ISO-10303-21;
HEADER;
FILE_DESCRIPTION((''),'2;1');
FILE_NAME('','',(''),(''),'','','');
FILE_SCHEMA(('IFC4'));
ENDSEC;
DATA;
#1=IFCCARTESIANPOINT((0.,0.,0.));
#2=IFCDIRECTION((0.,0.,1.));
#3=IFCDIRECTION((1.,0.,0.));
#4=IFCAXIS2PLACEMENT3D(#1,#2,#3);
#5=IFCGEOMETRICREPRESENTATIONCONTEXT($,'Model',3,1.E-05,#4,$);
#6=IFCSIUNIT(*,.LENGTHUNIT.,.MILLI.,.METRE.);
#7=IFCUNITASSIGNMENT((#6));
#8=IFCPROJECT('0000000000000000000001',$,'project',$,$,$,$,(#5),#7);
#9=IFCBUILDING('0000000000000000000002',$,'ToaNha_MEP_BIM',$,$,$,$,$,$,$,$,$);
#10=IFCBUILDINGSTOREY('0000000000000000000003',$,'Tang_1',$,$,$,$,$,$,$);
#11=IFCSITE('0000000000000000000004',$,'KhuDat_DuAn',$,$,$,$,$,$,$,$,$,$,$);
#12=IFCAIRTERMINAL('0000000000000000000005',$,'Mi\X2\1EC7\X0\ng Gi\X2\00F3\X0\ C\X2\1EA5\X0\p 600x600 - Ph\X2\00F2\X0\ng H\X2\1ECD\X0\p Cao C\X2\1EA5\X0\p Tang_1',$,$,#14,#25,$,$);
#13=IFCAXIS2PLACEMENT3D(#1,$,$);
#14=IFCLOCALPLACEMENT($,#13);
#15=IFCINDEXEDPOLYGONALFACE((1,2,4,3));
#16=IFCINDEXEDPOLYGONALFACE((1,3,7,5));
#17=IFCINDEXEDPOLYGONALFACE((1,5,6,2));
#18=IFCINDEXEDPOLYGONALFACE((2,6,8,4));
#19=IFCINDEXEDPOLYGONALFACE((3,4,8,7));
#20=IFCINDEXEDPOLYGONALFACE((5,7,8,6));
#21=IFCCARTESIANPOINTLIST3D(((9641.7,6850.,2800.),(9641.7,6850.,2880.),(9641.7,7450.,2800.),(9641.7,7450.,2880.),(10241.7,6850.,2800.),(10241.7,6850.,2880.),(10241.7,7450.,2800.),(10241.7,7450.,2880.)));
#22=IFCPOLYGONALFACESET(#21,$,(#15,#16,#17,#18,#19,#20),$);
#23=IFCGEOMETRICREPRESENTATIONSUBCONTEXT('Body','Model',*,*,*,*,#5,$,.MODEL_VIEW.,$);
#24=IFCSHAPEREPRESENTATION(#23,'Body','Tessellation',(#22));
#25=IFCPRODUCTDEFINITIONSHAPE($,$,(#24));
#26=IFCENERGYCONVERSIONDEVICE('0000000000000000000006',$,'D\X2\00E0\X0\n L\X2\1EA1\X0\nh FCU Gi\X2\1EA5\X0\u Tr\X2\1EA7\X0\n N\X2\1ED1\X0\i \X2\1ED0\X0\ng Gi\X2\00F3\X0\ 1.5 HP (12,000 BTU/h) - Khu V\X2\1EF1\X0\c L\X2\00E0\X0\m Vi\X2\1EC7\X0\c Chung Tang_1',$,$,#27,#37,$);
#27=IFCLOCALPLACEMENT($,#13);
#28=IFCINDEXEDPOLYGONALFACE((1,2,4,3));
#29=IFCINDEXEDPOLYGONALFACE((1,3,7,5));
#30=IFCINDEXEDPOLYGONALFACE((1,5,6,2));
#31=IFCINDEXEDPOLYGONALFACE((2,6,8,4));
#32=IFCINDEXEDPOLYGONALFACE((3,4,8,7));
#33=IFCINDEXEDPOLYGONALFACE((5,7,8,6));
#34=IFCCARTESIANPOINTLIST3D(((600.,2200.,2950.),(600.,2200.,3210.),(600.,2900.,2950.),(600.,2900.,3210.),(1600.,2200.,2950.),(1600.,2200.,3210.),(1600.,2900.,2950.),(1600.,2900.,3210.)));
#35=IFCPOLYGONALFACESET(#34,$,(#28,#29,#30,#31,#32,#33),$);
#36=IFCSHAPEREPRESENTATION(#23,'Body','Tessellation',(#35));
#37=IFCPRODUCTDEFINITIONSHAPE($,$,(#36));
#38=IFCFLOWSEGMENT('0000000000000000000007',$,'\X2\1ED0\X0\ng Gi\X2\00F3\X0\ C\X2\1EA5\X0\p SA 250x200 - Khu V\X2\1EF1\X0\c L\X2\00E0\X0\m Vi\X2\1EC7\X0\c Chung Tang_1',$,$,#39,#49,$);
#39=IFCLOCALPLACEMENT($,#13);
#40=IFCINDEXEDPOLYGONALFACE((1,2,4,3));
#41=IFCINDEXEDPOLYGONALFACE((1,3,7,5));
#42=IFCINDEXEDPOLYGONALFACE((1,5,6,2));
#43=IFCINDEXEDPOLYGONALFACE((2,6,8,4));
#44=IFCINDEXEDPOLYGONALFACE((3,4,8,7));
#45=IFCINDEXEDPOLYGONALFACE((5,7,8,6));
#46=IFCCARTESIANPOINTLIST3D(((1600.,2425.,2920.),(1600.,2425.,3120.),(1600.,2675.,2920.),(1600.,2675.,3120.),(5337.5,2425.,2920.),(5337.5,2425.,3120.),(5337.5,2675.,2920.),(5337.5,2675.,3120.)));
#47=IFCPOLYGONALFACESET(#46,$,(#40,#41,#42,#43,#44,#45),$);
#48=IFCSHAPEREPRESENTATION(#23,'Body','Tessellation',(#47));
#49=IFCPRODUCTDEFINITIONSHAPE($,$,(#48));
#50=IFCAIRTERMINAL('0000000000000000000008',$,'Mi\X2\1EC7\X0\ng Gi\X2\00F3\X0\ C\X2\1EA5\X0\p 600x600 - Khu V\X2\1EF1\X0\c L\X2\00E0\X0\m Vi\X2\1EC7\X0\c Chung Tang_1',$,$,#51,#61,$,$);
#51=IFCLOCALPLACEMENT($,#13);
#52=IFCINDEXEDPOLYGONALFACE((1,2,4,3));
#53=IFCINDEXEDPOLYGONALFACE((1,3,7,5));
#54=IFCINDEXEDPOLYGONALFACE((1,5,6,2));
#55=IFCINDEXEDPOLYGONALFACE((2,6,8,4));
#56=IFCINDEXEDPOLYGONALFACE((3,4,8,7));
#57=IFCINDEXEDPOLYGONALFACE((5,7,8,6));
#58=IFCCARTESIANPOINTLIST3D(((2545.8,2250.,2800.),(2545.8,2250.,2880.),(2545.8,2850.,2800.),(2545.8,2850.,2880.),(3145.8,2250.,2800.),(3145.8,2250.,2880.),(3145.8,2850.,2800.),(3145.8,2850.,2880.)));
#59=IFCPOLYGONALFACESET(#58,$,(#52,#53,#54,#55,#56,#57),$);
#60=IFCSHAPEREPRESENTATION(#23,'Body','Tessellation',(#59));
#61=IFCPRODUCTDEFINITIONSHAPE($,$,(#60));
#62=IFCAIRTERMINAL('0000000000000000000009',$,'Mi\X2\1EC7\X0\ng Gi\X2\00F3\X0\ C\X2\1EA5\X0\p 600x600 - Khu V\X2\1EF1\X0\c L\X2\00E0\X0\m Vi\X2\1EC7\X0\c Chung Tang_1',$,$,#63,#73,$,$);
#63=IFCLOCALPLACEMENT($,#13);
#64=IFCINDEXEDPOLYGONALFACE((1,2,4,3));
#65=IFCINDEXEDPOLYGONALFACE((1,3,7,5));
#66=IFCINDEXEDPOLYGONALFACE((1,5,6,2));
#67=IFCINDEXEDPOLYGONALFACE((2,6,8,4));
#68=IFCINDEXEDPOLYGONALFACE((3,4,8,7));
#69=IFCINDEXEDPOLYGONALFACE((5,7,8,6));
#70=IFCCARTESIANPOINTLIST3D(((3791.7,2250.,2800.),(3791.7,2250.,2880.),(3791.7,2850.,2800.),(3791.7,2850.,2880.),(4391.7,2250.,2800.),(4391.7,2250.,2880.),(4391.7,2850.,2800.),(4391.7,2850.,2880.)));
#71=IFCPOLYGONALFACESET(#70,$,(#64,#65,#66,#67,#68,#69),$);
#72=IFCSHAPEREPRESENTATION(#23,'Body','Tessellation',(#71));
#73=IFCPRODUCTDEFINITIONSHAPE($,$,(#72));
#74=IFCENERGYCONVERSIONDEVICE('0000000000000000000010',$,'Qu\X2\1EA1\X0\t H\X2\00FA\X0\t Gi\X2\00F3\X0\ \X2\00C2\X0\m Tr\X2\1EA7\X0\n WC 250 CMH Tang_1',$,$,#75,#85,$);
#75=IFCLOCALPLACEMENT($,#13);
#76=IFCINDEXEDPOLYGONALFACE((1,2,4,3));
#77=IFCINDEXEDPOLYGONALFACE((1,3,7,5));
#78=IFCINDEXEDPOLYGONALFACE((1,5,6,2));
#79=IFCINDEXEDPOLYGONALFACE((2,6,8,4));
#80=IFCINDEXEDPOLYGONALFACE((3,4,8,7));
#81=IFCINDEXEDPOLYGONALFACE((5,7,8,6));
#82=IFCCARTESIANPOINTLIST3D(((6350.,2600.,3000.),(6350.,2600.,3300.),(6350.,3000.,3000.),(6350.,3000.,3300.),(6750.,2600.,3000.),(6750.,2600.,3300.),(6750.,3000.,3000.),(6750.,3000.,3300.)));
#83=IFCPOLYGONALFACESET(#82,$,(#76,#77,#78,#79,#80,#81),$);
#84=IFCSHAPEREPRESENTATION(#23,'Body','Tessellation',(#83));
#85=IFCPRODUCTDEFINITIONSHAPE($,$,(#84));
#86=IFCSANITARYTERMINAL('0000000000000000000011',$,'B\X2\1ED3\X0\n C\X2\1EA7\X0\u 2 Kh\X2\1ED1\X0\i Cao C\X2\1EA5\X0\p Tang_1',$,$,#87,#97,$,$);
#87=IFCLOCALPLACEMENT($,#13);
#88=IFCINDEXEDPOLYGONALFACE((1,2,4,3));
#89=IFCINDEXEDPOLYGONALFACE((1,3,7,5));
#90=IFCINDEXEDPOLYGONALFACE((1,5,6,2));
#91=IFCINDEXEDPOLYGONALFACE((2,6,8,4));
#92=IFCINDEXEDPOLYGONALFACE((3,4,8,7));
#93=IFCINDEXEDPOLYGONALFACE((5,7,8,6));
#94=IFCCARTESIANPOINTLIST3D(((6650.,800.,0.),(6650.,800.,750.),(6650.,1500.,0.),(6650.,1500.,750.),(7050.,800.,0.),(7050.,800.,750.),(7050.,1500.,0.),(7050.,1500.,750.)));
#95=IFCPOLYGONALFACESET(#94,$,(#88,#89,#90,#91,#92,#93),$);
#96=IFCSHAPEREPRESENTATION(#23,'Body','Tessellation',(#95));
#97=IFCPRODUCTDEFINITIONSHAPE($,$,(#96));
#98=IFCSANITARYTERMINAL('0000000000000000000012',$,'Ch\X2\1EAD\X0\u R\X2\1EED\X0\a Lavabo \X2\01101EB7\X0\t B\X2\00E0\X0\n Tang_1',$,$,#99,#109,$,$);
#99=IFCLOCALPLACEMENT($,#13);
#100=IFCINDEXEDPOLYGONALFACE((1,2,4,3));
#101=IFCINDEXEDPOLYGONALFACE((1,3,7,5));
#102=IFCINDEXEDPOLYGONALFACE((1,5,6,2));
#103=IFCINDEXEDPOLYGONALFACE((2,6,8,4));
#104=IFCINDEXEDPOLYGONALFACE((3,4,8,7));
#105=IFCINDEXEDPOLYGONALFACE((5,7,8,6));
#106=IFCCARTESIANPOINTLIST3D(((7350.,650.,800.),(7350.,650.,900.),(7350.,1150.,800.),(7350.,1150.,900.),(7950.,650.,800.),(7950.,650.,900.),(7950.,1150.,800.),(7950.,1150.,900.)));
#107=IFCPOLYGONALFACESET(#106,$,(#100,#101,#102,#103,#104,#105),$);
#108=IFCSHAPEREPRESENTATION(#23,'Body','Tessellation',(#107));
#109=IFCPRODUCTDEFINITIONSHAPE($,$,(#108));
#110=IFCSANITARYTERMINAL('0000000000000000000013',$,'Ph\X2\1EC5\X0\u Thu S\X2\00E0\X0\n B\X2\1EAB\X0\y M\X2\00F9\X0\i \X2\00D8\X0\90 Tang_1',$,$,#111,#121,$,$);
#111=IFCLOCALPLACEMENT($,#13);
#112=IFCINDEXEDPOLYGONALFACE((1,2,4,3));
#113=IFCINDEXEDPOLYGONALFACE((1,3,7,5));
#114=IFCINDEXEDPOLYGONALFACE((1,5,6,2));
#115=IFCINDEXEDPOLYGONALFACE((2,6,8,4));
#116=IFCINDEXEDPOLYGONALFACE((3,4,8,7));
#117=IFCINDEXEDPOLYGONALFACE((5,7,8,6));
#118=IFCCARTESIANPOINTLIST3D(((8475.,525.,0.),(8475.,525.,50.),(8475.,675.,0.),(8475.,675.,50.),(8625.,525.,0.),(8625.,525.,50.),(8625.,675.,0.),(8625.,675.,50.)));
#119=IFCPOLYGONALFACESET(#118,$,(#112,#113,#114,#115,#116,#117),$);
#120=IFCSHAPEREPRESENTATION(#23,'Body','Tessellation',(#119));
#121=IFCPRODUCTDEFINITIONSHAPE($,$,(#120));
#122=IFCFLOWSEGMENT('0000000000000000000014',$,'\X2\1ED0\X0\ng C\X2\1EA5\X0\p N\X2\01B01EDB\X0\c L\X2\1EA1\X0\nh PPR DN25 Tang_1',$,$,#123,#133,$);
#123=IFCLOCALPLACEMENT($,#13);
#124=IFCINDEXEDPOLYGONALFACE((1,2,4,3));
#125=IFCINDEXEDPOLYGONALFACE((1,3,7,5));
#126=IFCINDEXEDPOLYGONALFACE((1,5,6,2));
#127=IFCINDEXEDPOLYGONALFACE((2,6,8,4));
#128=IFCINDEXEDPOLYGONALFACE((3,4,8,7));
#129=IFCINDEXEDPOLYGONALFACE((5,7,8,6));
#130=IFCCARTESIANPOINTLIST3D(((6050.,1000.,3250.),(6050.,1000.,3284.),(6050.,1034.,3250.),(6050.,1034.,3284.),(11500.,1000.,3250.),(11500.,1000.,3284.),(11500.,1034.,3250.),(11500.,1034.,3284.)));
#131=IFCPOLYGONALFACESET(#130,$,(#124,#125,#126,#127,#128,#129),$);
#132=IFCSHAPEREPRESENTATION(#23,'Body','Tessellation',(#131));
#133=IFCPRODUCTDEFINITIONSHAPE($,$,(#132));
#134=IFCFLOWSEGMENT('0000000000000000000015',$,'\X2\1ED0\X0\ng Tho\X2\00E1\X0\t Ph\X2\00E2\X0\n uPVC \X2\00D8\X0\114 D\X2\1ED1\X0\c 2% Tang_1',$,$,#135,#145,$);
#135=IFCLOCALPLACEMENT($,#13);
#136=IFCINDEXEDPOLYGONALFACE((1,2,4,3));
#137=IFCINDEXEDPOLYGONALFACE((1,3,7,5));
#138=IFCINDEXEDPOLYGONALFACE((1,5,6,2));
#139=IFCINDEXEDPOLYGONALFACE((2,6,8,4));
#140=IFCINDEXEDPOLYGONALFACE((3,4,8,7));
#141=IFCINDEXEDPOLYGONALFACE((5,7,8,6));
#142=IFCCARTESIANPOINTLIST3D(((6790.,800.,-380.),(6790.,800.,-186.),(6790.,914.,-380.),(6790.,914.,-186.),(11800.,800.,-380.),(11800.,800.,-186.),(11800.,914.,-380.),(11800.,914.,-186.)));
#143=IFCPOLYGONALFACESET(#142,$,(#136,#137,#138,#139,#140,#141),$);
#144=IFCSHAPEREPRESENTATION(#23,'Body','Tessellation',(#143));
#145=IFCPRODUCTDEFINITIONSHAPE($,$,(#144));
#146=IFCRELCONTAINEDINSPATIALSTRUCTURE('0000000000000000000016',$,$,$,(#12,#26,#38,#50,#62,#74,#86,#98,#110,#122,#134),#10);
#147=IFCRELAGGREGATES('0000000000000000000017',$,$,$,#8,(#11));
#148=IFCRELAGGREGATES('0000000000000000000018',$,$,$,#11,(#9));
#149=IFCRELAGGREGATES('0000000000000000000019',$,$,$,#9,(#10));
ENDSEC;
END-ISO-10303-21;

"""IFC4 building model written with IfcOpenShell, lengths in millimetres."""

from ifc_helpers import new_model, si_unit, frame, origin_with_axes, context, subcontext, project, spatial, polyline, outline, extrude, element, save


model = new_model("IFC4")

# Units and contexts
model_context = context("Model", 3, precision=1e-05, world=origin_with_axes())
body_context = subcontext(model_context, "Body", "Model", "MODEL_VIEW")
ifc_project = project(units=[si_unit("LENGTHUNIT", "METRE", prefix="MILLI")], contexts=[model_context])

# Site, building, storey
site = spatial("IfcSite", under=ifc_project, Name="KhuDat_DuAn")
building = spatial("IfcBuilding", under=site, Name="ToaNha_MEP_BIM")
storey = spatial("IfcBuildingStorey", under=building, Name="Tang_1")

# Air terminal
element("IfcAirTerminal", 1, inside=storey, Name="Miệng Gió Cấp 600x600 - Phòng Họp Cao Cấp Tang_1", context=body_context, shape_type="SweptSolid", body=[
    extrude(outline(polyline([(9641.7, 6850.0), (10241.7, 6850.0), (10241.7, 7450.0), (9641.7, 7450.0), (9641.7, 6850.0)])), frame((0.0, 0.0, 2800.0), z_axis=(0.0, 0.0, 1.0), x_axis=(1.0, 0.0, 0.0)), (0.0, 0.0, 1.0), 80.0),
])

# Energy conversion device
element("IfcEnergyConversionDevice", 2, inside=storey, Name="Dàn Lạnh FCU Giấu Trần Nối Ống Gió 1.5 HP (12,000 BTU/h) - Khu Vực Làm Việc Chung Tang_1", context=body_context, shape_type="SweptSolid", body=[
    extrude(outline(polyline([(600.0, 2200.0), (1600.0, 2200.0), (1600.0, 2900.0), (600.0, 2900.0), (600.0, 2200.0)])), frame((0.0, 0.0, 2950.0), z_axis=(0.0, 0.0, 1.0), x_axis=(1.0, 0.0, 0.0)), (0.0, 0.0, 1.0), 260.0),
])

# Flow segment
element("IfcFlowSegment", 3, inside=storey, Name="Ống Gió Cấp SA 250x200 - Khu Vực Làm Việc Chung Tang_1", context=body_context, shape_type="SweptSolid", body=[
    extrude(outline(polyline([(1600.0, 2425.0), (5337.5, 2425.0), (5337.5, 2675.0), (1600.0, 2675.0), (1600.0, 2425.0)])), frame((0.0, 0.0, 2920.0), z_axis=(0.0, 0.0, 1.0), x_axis=(1.0, 0.0, 0.0)), (0.0, 0.0, 1.0), 200.0),
])

# Air terminals
element("IfcAirTerminal", 4, inside=storey, Name="Miệng Gió Cấp 600x600 - Khu Vực Làm Việc Chung Tang_1", context=body_context, shape_type="SweptSolid", body=[
    extrude(outline(polyline([(2545.8, 2250.0), (3145.8, 2250.0), (3145.8, 2850.0), (2545.8, 2850.0), (2545.8, 2250.0)])), frame((0.0, 0.0, 2800.0), z_axis=(0.0, 0.0, 1.0), x_axis=(1.0, 0.0, 0.0)), (0.0, 0.0, 1.0), 80.0),
])
element("IfcAirTerminal", 5, inside=storey, Name="Miệng Gió Cấp 600x600 - Khu Vực Làm Việc Chung Tang_1", context=body_context, shape_type="SweptSolid", body=[
    extrude(outline(polyline([(3791.7, 2250.0), (4391.7, 2250.0), (4391.7, 2850.0), (3791.7, 2850.0), (3791.7, 2250.0)])), frame((0.0, 0.0, 2800.0), z_axis=(0.0, 0.0, 1.0), x_axis=(1.0, 0.0, 0.0)), (0.0, 0.0, 1.0), 80.0),
])

# Energy conversion device
element("IfcEnergyConversionDevice", 6, inside=storey, Name="Quạt Hút Gió Âm Trần WC 250 CMH Tang_1", context=body_context, shape_type="SweptSolid", body=[
    extrude(outline(polyline([(6350.0, 2600.0), (6750.0, 2600.0), (6750.0, 3000.0), (6350.0, 3000.0), (6350.0, 2600.0)])), frame((0.0, 0.0, 3000.0), z_axis=(0.0, 0.0, 1.0), x_axis=(1.0, 0.0, 0.0)), (0.0, 0.0, 1.0), 300.0),
])

# Sanitary terminals
element("IfcSanitaryTerminal", 7, inside=storey, Name="Bồn Cầu 2 Khối Cao Cấp Tang_1", context=body_context, shape_type="SweptSolid", body=[
    extrude(outline(polyline([(6650.0, 800.0), (7050.0, 800.0), (7050.0, 1500.0), (6650.0, 1500.0), (6650.0, 800.0)])), origin_with_axes(), (0.0, 0.0, 1.0), 750.0),
])
element("IfcSanitaryTerminal", 8, inside=storey, Name="Chậu Rửa Lavabo Đặt Bàn Tang_1", context=body_context, shape_type="SweptSolid", body=[
    extrude(outline(polyline([(7350.0, 650.0), (7950.0, 650.0), (7950.0, 1150.0), (7350.0, 1150.0), (7350.0, 650.0)])), frame((0.0, 0.0, 800.0), z_axis=(0.0, 0.0, 1.0), x_axis=(1.0, 0.0, 0.0)), (0.0, 0.0, 1.0), 100.0),
])
element("IfcSanitaryTerminal", 9, inside=storey, Name="Phễu Thu Sàn Bẫy Mùi Ø90 Tang_1", context=body_context, shape_type="SweptSolid", body=[
    extrude(outline(polyline([(8475.0, 525.0), (8625.0, 525.0), (8625.0, 675.0), (8475.0, 675.0), (8475.0, 525.0)])), origin_with_axes(), (0.0, 0.0, 1.0), 50.0),
])

# Flow segments
element("IfcFlowSegment", 10, inside=storey, Name="Ống Cấp Nước Lạnh PPR DN25 Tang_1", context=body_context, shape_type="SweptSolid", body=[
    extrude(outline(polyline([(6050.0, 1000.0), (11500.0, 1000.0), (11500.0, 1034.0), (6050.0, 1034.0), (6050.0, 1000.0)])), frame((0.0, 0.0, 3250.0), z_axis=(0.0, 0.0, 1.0), x_axis=(1.0, 0.0, 0.0)), (0.0, 0.0, 1.0), 34.0),
])
element("IfcFlowSegment", 11, inside=storey, Name="Ống Thoát Phân uPVC Ø114 Dốc 2% Tang_1", context=body_context, shape_type="SweptSolid", body=[
    extrude(outline(polyline([(6790.0, 800.0), (11800.0, 800.0), (11800.0, 914.0), (6790.0, 914.0), (6790.0, 800.0)])), frame((0.0, 0.0, -380.0), z_axis=(0.0, 0.0, 1.0), x_axis=(1.0, 0.0, 0.0)), (0.0, 0.0, 1.0), 194.0),
])

save(model, "model.ifc")
